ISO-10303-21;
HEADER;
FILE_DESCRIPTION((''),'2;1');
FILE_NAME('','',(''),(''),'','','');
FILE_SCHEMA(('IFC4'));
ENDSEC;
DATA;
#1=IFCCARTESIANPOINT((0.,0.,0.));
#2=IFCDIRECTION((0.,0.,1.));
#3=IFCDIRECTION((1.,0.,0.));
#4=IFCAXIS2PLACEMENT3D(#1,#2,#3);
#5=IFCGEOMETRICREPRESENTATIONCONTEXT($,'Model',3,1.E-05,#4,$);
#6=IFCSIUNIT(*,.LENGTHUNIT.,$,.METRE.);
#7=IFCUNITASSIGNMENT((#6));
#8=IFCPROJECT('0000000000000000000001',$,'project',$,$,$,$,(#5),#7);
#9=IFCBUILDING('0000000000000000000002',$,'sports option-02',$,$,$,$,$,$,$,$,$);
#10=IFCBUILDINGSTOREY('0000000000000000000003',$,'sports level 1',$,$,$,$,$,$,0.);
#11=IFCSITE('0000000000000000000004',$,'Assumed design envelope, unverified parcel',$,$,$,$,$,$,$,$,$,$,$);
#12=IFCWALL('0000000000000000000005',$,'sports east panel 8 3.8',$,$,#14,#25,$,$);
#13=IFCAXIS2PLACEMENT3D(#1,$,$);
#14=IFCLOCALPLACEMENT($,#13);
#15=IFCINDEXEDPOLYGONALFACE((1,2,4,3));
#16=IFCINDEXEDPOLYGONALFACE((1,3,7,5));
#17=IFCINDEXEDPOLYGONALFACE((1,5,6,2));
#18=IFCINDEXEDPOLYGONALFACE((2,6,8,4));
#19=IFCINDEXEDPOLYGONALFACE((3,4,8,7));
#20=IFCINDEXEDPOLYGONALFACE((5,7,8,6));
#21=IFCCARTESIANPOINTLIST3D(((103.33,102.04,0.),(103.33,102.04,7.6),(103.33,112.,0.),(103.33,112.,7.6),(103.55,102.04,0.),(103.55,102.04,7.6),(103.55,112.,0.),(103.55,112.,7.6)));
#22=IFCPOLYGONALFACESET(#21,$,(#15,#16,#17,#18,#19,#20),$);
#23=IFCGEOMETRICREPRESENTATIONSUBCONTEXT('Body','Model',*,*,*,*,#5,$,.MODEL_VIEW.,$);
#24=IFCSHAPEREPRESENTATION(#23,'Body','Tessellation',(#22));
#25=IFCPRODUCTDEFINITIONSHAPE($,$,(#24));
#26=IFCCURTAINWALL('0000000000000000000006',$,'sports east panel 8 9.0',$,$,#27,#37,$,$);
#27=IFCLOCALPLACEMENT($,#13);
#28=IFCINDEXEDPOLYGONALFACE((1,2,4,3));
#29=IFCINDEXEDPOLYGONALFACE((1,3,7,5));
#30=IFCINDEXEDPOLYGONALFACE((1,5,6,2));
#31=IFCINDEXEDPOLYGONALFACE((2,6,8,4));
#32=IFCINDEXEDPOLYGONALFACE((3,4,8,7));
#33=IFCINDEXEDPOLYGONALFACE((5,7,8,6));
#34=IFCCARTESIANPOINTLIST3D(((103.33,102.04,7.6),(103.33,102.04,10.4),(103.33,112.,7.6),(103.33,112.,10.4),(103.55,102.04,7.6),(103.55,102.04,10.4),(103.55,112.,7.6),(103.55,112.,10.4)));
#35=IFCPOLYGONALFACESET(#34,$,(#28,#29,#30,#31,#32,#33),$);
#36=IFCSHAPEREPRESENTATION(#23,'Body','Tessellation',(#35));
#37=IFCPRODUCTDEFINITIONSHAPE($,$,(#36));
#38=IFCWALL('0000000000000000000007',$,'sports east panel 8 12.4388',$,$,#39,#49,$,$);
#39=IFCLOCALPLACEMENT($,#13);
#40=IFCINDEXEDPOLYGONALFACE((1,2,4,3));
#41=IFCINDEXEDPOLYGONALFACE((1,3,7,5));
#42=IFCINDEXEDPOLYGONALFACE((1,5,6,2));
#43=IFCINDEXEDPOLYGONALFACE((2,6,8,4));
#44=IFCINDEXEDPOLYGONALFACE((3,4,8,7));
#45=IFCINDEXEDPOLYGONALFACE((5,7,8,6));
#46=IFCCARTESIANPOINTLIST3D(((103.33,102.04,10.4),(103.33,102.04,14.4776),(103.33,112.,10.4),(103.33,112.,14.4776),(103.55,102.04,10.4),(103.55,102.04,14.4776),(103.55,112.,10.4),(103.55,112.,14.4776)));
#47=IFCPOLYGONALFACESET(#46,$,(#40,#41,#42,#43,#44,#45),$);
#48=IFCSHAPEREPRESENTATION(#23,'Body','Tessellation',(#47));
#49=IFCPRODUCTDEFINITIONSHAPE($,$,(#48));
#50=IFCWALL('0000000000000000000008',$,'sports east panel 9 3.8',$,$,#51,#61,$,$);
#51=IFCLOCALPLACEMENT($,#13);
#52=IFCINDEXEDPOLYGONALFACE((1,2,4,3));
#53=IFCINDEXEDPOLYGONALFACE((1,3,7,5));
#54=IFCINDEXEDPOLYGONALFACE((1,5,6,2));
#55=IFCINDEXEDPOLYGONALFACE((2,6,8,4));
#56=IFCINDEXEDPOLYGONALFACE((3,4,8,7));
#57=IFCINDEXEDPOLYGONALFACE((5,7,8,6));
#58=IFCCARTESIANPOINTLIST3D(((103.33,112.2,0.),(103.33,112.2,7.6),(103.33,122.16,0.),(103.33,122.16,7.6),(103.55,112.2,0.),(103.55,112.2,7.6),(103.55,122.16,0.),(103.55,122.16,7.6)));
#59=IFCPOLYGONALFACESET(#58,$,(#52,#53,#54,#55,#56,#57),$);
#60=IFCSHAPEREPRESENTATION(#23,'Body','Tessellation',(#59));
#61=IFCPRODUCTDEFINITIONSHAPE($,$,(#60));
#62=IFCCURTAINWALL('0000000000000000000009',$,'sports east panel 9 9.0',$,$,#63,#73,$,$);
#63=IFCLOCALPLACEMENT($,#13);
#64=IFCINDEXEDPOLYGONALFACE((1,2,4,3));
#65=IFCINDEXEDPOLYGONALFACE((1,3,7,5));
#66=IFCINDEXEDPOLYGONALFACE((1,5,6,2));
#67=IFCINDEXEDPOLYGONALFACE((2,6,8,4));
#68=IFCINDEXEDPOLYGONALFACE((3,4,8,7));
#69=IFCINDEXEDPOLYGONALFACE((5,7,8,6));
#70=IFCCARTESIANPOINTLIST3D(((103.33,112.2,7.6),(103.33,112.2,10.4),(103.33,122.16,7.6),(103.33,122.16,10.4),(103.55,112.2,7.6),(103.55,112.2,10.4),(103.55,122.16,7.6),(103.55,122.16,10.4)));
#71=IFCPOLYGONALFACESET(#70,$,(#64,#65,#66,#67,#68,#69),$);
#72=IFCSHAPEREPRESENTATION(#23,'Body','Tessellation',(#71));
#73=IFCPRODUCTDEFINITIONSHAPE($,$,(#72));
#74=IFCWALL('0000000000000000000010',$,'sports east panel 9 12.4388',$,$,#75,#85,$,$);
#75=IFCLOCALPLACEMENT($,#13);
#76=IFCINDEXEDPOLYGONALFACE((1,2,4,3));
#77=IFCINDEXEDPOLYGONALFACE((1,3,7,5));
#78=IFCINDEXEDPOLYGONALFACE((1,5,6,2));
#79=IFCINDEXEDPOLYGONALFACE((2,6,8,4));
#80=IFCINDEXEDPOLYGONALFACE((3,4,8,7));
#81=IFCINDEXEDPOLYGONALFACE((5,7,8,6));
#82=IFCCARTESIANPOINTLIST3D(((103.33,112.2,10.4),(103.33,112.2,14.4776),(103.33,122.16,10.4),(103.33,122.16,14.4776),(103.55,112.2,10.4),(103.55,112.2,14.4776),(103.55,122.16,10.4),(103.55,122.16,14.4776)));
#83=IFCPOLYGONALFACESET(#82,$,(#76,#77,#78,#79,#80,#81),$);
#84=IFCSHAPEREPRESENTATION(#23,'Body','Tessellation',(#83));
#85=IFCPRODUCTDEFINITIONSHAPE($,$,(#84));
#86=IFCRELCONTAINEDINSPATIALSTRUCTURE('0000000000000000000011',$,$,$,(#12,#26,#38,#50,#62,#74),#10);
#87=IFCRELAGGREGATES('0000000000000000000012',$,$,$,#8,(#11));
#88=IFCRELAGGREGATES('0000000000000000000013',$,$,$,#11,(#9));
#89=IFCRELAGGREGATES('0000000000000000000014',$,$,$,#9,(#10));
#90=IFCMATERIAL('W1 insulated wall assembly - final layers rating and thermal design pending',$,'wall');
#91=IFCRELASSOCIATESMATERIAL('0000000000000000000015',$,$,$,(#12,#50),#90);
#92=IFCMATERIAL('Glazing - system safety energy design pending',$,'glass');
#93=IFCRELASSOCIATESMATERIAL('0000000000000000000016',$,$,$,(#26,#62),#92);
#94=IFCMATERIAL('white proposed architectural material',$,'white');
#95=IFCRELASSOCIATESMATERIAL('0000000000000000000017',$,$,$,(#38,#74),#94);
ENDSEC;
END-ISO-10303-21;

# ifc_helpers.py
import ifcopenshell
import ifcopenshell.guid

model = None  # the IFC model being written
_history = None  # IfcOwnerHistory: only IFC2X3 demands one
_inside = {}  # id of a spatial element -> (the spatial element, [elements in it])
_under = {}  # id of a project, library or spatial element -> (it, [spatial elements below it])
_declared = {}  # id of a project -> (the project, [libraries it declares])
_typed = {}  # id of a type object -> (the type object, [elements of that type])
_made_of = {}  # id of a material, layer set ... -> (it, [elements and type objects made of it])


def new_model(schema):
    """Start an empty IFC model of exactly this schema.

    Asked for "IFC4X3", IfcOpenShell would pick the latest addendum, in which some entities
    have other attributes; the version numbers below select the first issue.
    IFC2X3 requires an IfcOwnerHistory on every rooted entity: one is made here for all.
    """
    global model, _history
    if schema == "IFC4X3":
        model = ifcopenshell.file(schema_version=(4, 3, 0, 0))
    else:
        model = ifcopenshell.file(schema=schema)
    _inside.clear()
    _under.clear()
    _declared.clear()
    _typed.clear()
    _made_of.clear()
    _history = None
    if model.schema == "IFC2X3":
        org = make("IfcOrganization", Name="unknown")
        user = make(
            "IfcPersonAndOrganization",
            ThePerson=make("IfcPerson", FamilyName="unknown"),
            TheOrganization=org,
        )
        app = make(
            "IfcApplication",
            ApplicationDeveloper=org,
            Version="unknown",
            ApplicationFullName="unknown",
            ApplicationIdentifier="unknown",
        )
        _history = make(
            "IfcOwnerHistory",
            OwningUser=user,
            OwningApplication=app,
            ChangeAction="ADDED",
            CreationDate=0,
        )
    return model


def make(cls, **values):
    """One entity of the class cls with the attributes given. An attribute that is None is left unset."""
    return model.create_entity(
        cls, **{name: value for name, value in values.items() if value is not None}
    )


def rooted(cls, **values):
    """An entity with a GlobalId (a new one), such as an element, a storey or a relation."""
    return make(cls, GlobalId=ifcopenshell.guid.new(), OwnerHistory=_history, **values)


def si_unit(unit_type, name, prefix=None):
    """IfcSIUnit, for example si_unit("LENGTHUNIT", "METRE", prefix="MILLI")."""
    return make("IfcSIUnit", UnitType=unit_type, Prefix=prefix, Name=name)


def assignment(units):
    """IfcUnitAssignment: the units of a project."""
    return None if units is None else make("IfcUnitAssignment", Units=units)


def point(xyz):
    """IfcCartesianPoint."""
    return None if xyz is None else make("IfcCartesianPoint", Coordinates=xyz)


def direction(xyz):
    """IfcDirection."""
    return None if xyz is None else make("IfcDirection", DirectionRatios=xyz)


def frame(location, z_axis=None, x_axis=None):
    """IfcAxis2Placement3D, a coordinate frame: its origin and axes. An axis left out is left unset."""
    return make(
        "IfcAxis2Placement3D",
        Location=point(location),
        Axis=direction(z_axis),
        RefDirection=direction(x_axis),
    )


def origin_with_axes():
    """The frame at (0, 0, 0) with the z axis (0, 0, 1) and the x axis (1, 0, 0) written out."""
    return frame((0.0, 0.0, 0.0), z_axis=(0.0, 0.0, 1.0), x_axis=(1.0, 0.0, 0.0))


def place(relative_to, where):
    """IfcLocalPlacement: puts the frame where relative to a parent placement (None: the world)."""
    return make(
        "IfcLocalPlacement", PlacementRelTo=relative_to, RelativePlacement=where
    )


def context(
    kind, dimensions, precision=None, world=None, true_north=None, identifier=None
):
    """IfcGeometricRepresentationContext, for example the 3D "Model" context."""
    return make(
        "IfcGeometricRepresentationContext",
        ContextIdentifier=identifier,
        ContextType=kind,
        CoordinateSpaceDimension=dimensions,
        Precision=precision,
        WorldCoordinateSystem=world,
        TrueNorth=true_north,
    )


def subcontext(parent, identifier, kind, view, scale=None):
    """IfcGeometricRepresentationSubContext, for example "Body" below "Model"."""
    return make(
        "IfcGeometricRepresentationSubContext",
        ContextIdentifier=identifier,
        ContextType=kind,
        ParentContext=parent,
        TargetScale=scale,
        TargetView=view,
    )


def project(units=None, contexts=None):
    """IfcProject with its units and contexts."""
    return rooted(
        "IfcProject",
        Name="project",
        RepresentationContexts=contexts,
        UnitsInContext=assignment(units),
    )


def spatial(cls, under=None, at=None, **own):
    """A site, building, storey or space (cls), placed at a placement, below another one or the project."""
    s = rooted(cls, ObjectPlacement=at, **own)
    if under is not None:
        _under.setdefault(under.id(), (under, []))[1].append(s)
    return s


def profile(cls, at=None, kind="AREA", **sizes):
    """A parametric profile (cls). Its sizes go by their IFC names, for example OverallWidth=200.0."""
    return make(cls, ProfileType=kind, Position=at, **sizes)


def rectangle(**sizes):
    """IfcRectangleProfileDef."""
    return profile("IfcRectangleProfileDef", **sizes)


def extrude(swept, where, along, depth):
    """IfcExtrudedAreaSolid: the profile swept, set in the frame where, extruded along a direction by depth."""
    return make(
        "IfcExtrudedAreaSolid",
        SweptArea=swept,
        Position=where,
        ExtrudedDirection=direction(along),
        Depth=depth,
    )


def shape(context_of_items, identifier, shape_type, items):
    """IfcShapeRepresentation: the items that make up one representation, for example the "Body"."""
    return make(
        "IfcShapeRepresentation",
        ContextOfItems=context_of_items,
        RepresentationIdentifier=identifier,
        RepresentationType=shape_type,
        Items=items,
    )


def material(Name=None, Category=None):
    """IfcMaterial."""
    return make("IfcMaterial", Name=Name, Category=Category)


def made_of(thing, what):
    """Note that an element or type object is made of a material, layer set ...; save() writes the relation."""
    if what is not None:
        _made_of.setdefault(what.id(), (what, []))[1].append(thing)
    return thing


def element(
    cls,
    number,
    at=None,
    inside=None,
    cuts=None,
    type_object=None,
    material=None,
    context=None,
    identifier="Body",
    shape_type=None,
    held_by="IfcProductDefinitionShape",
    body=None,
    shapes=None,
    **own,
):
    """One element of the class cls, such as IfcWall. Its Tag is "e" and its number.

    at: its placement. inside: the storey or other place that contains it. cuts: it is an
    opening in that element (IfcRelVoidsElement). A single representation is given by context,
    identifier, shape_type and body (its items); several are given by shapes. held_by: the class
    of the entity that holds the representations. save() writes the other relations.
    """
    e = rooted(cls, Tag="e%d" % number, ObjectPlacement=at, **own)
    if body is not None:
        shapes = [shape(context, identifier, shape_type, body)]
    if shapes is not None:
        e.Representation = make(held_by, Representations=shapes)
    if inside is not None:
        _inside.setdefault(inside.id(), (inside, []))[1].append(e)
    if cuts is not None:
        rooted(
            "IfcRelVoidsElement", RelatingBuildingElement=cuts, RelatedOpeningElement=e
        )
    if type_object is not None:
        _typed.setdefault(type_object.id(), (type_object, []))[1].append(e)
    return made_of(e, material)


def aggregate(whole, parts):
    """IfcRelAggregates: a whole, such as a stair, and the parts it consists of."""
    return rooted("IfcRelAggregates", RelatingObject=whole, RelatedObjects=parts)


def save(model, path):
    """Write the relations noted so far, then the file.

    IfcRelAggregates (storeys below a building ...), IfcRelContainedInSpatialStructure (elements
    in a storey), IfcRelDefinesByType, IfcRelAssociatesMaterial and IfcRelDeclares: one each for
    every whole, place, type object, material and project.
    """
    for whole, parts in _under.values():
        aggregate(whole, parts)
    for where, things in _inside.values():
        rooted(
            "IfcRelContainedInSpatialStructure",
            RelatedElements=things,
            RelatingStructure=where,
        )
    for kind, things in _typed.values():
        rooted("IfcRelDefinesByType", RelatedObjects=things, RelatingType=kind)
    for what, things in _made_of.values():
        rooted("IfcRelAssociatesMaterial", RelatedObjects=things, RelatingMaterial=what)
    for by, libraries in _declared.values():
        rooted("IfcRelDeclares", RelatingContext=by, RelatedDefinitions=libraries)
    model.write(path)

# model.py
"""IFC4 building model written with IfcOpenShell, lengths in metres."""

from ifc_helpers import new_model, si_unit, frame, origin_with_axes, place, context, subcontext, project, spatial, rectangle, extrude, material, element, save


model = new_model("IFC4")

# Units and contexts
model_context = context("Model", 3, precision=1e-05, world=origin_with_axes())
body_context = subcontext(model_context, "Body", "Model", "MODEL_VIEW")
ifc_project = project(units=[si_unit("LENGTHUNIT", "METRE")], contexts=[model_context])

# Site, building, storey
site = spatial("IfcSite", under=ifc_project, Name="Assumed design envelope, unverified parcel")
building = spatial("IfcBuilding", under=site, Name="sports option-02")
storey = spatial("IfcBuildingStorey", under=building, Name="sports level 1", Elevation=0.0)

# Wall
ifc_material_1 = material(Name="W1 insulated wall assembly - final layers rating and thermal design pending", Category="wall")
wall_1_placement = place(None, frame((103.44, 107.02, 0.0), z_axis=(0.0, 0.0, 1.0), x_axis=(1.0, 0.0, 0.0)))
element("IfcWall", 1, at=wall_1_placement, inside=storey, material=ifc_material_1, Name="sports east panel 8 3.8", context=body_context, shape_type="SweptSolid", body=[
    extrude(rectangle(XDim=0.22, YDim=9.96), origin_with_axes(), (0.0, 0.0, 1.0), 7.6),
])

# Curtain wall
ifc_material_2 = material(Name="Glazing - system safety energy design pending", Category="glass")
curtain_wall_1_placement = place(None, frame((103.44, 107.02, 7.6), z_axis=(0.0, 0.0, 1.0), x_axis=(1.0, 0.0, 0.0)))
element("IfcCurtainWall", 2, at=curtain_wall_1_placement, inside=storey, material=ifc_material_2, Name="sports east panel 8 9.0", context=body_context, shape_type="SweptSolid", body=[
    extrude(rectangle(XDim=0.22, YDim=9.96), origin_with_axes(), (0.0, 0.0, 1.0), 2.8),
])

# Walls
ifc_material_3 = material(Name="white proposed architectural material", Category="white")
wall_2_placement = place(None, frame((103.44, 107.02, 10.4), z_axis=(0.0, 0.0, 1.0), x_axis=(1.0, 0.0, 0.0)))
element("IfcWall", 3, at=wall_2_placement, inside=storey, material=ifc_material_3, Name="sports east panel 8 12.4388", context=body_context, shape_type="SweptSolid", body=[
    extrude(rectangle(XDim=0.22, YDim=9.96), origin_with_axes(), (0.0, 0.0, 1.0), 4.0776),
])
wall_3_placement = place(None, frame((103.44, 117.18, 0.0), z_axis=(0.0, 0.0, 1.0), x_axis=(1.0, 0.0, 0.0)))
element("IfcWall", 4, at=wall_3_placement, inside=storey, material=ifc_material_1, Name="sports east panel 9 3.8", context=body_context, shape_type="SweptSolid", body=[
    extrude(rectangle(XDim=0.22, YDim=9.96), origin_with_axes(), (0.0, 0.0, 1.0), 7.6),
])

# Curtain wall
curtain_wall_2_placement = place(None, frame((103.44, 117.18, 7.6), z_axis=(0.0, 0.0, 1.0), x_axis=(1.0, 0.0, 0.0)))
element("IfcCurtainWall", 5, at=curtain_wall_2_placement, inside=storey, material=ifc_material_2, Name="sports east panel 9 9.0", context=body_context, shape_type="SweptSolid", body=[
    extrude(rectangle(XDim=0.22, YDim=9.96), origin_with_axes(), (0.0, 0.0, 1.0), 2.8),
])

# Wall
wall_4_placement = place(None, frame((103.44, 117.18, 10.4), z_axis=(0.0, 0.0, 1.0), x_axis=(1.0, 0.0, 0.0)))
element("IfcWall", 6, at=wall_4_placement, inside=storey, material=ifc_material_3, Name="sports east panel 9 12.4388", context=body_context, shape_type="SweptSolid", body=[
    extrude(rectangle(XDim=0.22, YDim=9.96), origin_with_axes(), (0.0, 0.0, 1.0), 4.0776),
])

save(model, "model.ifc")
